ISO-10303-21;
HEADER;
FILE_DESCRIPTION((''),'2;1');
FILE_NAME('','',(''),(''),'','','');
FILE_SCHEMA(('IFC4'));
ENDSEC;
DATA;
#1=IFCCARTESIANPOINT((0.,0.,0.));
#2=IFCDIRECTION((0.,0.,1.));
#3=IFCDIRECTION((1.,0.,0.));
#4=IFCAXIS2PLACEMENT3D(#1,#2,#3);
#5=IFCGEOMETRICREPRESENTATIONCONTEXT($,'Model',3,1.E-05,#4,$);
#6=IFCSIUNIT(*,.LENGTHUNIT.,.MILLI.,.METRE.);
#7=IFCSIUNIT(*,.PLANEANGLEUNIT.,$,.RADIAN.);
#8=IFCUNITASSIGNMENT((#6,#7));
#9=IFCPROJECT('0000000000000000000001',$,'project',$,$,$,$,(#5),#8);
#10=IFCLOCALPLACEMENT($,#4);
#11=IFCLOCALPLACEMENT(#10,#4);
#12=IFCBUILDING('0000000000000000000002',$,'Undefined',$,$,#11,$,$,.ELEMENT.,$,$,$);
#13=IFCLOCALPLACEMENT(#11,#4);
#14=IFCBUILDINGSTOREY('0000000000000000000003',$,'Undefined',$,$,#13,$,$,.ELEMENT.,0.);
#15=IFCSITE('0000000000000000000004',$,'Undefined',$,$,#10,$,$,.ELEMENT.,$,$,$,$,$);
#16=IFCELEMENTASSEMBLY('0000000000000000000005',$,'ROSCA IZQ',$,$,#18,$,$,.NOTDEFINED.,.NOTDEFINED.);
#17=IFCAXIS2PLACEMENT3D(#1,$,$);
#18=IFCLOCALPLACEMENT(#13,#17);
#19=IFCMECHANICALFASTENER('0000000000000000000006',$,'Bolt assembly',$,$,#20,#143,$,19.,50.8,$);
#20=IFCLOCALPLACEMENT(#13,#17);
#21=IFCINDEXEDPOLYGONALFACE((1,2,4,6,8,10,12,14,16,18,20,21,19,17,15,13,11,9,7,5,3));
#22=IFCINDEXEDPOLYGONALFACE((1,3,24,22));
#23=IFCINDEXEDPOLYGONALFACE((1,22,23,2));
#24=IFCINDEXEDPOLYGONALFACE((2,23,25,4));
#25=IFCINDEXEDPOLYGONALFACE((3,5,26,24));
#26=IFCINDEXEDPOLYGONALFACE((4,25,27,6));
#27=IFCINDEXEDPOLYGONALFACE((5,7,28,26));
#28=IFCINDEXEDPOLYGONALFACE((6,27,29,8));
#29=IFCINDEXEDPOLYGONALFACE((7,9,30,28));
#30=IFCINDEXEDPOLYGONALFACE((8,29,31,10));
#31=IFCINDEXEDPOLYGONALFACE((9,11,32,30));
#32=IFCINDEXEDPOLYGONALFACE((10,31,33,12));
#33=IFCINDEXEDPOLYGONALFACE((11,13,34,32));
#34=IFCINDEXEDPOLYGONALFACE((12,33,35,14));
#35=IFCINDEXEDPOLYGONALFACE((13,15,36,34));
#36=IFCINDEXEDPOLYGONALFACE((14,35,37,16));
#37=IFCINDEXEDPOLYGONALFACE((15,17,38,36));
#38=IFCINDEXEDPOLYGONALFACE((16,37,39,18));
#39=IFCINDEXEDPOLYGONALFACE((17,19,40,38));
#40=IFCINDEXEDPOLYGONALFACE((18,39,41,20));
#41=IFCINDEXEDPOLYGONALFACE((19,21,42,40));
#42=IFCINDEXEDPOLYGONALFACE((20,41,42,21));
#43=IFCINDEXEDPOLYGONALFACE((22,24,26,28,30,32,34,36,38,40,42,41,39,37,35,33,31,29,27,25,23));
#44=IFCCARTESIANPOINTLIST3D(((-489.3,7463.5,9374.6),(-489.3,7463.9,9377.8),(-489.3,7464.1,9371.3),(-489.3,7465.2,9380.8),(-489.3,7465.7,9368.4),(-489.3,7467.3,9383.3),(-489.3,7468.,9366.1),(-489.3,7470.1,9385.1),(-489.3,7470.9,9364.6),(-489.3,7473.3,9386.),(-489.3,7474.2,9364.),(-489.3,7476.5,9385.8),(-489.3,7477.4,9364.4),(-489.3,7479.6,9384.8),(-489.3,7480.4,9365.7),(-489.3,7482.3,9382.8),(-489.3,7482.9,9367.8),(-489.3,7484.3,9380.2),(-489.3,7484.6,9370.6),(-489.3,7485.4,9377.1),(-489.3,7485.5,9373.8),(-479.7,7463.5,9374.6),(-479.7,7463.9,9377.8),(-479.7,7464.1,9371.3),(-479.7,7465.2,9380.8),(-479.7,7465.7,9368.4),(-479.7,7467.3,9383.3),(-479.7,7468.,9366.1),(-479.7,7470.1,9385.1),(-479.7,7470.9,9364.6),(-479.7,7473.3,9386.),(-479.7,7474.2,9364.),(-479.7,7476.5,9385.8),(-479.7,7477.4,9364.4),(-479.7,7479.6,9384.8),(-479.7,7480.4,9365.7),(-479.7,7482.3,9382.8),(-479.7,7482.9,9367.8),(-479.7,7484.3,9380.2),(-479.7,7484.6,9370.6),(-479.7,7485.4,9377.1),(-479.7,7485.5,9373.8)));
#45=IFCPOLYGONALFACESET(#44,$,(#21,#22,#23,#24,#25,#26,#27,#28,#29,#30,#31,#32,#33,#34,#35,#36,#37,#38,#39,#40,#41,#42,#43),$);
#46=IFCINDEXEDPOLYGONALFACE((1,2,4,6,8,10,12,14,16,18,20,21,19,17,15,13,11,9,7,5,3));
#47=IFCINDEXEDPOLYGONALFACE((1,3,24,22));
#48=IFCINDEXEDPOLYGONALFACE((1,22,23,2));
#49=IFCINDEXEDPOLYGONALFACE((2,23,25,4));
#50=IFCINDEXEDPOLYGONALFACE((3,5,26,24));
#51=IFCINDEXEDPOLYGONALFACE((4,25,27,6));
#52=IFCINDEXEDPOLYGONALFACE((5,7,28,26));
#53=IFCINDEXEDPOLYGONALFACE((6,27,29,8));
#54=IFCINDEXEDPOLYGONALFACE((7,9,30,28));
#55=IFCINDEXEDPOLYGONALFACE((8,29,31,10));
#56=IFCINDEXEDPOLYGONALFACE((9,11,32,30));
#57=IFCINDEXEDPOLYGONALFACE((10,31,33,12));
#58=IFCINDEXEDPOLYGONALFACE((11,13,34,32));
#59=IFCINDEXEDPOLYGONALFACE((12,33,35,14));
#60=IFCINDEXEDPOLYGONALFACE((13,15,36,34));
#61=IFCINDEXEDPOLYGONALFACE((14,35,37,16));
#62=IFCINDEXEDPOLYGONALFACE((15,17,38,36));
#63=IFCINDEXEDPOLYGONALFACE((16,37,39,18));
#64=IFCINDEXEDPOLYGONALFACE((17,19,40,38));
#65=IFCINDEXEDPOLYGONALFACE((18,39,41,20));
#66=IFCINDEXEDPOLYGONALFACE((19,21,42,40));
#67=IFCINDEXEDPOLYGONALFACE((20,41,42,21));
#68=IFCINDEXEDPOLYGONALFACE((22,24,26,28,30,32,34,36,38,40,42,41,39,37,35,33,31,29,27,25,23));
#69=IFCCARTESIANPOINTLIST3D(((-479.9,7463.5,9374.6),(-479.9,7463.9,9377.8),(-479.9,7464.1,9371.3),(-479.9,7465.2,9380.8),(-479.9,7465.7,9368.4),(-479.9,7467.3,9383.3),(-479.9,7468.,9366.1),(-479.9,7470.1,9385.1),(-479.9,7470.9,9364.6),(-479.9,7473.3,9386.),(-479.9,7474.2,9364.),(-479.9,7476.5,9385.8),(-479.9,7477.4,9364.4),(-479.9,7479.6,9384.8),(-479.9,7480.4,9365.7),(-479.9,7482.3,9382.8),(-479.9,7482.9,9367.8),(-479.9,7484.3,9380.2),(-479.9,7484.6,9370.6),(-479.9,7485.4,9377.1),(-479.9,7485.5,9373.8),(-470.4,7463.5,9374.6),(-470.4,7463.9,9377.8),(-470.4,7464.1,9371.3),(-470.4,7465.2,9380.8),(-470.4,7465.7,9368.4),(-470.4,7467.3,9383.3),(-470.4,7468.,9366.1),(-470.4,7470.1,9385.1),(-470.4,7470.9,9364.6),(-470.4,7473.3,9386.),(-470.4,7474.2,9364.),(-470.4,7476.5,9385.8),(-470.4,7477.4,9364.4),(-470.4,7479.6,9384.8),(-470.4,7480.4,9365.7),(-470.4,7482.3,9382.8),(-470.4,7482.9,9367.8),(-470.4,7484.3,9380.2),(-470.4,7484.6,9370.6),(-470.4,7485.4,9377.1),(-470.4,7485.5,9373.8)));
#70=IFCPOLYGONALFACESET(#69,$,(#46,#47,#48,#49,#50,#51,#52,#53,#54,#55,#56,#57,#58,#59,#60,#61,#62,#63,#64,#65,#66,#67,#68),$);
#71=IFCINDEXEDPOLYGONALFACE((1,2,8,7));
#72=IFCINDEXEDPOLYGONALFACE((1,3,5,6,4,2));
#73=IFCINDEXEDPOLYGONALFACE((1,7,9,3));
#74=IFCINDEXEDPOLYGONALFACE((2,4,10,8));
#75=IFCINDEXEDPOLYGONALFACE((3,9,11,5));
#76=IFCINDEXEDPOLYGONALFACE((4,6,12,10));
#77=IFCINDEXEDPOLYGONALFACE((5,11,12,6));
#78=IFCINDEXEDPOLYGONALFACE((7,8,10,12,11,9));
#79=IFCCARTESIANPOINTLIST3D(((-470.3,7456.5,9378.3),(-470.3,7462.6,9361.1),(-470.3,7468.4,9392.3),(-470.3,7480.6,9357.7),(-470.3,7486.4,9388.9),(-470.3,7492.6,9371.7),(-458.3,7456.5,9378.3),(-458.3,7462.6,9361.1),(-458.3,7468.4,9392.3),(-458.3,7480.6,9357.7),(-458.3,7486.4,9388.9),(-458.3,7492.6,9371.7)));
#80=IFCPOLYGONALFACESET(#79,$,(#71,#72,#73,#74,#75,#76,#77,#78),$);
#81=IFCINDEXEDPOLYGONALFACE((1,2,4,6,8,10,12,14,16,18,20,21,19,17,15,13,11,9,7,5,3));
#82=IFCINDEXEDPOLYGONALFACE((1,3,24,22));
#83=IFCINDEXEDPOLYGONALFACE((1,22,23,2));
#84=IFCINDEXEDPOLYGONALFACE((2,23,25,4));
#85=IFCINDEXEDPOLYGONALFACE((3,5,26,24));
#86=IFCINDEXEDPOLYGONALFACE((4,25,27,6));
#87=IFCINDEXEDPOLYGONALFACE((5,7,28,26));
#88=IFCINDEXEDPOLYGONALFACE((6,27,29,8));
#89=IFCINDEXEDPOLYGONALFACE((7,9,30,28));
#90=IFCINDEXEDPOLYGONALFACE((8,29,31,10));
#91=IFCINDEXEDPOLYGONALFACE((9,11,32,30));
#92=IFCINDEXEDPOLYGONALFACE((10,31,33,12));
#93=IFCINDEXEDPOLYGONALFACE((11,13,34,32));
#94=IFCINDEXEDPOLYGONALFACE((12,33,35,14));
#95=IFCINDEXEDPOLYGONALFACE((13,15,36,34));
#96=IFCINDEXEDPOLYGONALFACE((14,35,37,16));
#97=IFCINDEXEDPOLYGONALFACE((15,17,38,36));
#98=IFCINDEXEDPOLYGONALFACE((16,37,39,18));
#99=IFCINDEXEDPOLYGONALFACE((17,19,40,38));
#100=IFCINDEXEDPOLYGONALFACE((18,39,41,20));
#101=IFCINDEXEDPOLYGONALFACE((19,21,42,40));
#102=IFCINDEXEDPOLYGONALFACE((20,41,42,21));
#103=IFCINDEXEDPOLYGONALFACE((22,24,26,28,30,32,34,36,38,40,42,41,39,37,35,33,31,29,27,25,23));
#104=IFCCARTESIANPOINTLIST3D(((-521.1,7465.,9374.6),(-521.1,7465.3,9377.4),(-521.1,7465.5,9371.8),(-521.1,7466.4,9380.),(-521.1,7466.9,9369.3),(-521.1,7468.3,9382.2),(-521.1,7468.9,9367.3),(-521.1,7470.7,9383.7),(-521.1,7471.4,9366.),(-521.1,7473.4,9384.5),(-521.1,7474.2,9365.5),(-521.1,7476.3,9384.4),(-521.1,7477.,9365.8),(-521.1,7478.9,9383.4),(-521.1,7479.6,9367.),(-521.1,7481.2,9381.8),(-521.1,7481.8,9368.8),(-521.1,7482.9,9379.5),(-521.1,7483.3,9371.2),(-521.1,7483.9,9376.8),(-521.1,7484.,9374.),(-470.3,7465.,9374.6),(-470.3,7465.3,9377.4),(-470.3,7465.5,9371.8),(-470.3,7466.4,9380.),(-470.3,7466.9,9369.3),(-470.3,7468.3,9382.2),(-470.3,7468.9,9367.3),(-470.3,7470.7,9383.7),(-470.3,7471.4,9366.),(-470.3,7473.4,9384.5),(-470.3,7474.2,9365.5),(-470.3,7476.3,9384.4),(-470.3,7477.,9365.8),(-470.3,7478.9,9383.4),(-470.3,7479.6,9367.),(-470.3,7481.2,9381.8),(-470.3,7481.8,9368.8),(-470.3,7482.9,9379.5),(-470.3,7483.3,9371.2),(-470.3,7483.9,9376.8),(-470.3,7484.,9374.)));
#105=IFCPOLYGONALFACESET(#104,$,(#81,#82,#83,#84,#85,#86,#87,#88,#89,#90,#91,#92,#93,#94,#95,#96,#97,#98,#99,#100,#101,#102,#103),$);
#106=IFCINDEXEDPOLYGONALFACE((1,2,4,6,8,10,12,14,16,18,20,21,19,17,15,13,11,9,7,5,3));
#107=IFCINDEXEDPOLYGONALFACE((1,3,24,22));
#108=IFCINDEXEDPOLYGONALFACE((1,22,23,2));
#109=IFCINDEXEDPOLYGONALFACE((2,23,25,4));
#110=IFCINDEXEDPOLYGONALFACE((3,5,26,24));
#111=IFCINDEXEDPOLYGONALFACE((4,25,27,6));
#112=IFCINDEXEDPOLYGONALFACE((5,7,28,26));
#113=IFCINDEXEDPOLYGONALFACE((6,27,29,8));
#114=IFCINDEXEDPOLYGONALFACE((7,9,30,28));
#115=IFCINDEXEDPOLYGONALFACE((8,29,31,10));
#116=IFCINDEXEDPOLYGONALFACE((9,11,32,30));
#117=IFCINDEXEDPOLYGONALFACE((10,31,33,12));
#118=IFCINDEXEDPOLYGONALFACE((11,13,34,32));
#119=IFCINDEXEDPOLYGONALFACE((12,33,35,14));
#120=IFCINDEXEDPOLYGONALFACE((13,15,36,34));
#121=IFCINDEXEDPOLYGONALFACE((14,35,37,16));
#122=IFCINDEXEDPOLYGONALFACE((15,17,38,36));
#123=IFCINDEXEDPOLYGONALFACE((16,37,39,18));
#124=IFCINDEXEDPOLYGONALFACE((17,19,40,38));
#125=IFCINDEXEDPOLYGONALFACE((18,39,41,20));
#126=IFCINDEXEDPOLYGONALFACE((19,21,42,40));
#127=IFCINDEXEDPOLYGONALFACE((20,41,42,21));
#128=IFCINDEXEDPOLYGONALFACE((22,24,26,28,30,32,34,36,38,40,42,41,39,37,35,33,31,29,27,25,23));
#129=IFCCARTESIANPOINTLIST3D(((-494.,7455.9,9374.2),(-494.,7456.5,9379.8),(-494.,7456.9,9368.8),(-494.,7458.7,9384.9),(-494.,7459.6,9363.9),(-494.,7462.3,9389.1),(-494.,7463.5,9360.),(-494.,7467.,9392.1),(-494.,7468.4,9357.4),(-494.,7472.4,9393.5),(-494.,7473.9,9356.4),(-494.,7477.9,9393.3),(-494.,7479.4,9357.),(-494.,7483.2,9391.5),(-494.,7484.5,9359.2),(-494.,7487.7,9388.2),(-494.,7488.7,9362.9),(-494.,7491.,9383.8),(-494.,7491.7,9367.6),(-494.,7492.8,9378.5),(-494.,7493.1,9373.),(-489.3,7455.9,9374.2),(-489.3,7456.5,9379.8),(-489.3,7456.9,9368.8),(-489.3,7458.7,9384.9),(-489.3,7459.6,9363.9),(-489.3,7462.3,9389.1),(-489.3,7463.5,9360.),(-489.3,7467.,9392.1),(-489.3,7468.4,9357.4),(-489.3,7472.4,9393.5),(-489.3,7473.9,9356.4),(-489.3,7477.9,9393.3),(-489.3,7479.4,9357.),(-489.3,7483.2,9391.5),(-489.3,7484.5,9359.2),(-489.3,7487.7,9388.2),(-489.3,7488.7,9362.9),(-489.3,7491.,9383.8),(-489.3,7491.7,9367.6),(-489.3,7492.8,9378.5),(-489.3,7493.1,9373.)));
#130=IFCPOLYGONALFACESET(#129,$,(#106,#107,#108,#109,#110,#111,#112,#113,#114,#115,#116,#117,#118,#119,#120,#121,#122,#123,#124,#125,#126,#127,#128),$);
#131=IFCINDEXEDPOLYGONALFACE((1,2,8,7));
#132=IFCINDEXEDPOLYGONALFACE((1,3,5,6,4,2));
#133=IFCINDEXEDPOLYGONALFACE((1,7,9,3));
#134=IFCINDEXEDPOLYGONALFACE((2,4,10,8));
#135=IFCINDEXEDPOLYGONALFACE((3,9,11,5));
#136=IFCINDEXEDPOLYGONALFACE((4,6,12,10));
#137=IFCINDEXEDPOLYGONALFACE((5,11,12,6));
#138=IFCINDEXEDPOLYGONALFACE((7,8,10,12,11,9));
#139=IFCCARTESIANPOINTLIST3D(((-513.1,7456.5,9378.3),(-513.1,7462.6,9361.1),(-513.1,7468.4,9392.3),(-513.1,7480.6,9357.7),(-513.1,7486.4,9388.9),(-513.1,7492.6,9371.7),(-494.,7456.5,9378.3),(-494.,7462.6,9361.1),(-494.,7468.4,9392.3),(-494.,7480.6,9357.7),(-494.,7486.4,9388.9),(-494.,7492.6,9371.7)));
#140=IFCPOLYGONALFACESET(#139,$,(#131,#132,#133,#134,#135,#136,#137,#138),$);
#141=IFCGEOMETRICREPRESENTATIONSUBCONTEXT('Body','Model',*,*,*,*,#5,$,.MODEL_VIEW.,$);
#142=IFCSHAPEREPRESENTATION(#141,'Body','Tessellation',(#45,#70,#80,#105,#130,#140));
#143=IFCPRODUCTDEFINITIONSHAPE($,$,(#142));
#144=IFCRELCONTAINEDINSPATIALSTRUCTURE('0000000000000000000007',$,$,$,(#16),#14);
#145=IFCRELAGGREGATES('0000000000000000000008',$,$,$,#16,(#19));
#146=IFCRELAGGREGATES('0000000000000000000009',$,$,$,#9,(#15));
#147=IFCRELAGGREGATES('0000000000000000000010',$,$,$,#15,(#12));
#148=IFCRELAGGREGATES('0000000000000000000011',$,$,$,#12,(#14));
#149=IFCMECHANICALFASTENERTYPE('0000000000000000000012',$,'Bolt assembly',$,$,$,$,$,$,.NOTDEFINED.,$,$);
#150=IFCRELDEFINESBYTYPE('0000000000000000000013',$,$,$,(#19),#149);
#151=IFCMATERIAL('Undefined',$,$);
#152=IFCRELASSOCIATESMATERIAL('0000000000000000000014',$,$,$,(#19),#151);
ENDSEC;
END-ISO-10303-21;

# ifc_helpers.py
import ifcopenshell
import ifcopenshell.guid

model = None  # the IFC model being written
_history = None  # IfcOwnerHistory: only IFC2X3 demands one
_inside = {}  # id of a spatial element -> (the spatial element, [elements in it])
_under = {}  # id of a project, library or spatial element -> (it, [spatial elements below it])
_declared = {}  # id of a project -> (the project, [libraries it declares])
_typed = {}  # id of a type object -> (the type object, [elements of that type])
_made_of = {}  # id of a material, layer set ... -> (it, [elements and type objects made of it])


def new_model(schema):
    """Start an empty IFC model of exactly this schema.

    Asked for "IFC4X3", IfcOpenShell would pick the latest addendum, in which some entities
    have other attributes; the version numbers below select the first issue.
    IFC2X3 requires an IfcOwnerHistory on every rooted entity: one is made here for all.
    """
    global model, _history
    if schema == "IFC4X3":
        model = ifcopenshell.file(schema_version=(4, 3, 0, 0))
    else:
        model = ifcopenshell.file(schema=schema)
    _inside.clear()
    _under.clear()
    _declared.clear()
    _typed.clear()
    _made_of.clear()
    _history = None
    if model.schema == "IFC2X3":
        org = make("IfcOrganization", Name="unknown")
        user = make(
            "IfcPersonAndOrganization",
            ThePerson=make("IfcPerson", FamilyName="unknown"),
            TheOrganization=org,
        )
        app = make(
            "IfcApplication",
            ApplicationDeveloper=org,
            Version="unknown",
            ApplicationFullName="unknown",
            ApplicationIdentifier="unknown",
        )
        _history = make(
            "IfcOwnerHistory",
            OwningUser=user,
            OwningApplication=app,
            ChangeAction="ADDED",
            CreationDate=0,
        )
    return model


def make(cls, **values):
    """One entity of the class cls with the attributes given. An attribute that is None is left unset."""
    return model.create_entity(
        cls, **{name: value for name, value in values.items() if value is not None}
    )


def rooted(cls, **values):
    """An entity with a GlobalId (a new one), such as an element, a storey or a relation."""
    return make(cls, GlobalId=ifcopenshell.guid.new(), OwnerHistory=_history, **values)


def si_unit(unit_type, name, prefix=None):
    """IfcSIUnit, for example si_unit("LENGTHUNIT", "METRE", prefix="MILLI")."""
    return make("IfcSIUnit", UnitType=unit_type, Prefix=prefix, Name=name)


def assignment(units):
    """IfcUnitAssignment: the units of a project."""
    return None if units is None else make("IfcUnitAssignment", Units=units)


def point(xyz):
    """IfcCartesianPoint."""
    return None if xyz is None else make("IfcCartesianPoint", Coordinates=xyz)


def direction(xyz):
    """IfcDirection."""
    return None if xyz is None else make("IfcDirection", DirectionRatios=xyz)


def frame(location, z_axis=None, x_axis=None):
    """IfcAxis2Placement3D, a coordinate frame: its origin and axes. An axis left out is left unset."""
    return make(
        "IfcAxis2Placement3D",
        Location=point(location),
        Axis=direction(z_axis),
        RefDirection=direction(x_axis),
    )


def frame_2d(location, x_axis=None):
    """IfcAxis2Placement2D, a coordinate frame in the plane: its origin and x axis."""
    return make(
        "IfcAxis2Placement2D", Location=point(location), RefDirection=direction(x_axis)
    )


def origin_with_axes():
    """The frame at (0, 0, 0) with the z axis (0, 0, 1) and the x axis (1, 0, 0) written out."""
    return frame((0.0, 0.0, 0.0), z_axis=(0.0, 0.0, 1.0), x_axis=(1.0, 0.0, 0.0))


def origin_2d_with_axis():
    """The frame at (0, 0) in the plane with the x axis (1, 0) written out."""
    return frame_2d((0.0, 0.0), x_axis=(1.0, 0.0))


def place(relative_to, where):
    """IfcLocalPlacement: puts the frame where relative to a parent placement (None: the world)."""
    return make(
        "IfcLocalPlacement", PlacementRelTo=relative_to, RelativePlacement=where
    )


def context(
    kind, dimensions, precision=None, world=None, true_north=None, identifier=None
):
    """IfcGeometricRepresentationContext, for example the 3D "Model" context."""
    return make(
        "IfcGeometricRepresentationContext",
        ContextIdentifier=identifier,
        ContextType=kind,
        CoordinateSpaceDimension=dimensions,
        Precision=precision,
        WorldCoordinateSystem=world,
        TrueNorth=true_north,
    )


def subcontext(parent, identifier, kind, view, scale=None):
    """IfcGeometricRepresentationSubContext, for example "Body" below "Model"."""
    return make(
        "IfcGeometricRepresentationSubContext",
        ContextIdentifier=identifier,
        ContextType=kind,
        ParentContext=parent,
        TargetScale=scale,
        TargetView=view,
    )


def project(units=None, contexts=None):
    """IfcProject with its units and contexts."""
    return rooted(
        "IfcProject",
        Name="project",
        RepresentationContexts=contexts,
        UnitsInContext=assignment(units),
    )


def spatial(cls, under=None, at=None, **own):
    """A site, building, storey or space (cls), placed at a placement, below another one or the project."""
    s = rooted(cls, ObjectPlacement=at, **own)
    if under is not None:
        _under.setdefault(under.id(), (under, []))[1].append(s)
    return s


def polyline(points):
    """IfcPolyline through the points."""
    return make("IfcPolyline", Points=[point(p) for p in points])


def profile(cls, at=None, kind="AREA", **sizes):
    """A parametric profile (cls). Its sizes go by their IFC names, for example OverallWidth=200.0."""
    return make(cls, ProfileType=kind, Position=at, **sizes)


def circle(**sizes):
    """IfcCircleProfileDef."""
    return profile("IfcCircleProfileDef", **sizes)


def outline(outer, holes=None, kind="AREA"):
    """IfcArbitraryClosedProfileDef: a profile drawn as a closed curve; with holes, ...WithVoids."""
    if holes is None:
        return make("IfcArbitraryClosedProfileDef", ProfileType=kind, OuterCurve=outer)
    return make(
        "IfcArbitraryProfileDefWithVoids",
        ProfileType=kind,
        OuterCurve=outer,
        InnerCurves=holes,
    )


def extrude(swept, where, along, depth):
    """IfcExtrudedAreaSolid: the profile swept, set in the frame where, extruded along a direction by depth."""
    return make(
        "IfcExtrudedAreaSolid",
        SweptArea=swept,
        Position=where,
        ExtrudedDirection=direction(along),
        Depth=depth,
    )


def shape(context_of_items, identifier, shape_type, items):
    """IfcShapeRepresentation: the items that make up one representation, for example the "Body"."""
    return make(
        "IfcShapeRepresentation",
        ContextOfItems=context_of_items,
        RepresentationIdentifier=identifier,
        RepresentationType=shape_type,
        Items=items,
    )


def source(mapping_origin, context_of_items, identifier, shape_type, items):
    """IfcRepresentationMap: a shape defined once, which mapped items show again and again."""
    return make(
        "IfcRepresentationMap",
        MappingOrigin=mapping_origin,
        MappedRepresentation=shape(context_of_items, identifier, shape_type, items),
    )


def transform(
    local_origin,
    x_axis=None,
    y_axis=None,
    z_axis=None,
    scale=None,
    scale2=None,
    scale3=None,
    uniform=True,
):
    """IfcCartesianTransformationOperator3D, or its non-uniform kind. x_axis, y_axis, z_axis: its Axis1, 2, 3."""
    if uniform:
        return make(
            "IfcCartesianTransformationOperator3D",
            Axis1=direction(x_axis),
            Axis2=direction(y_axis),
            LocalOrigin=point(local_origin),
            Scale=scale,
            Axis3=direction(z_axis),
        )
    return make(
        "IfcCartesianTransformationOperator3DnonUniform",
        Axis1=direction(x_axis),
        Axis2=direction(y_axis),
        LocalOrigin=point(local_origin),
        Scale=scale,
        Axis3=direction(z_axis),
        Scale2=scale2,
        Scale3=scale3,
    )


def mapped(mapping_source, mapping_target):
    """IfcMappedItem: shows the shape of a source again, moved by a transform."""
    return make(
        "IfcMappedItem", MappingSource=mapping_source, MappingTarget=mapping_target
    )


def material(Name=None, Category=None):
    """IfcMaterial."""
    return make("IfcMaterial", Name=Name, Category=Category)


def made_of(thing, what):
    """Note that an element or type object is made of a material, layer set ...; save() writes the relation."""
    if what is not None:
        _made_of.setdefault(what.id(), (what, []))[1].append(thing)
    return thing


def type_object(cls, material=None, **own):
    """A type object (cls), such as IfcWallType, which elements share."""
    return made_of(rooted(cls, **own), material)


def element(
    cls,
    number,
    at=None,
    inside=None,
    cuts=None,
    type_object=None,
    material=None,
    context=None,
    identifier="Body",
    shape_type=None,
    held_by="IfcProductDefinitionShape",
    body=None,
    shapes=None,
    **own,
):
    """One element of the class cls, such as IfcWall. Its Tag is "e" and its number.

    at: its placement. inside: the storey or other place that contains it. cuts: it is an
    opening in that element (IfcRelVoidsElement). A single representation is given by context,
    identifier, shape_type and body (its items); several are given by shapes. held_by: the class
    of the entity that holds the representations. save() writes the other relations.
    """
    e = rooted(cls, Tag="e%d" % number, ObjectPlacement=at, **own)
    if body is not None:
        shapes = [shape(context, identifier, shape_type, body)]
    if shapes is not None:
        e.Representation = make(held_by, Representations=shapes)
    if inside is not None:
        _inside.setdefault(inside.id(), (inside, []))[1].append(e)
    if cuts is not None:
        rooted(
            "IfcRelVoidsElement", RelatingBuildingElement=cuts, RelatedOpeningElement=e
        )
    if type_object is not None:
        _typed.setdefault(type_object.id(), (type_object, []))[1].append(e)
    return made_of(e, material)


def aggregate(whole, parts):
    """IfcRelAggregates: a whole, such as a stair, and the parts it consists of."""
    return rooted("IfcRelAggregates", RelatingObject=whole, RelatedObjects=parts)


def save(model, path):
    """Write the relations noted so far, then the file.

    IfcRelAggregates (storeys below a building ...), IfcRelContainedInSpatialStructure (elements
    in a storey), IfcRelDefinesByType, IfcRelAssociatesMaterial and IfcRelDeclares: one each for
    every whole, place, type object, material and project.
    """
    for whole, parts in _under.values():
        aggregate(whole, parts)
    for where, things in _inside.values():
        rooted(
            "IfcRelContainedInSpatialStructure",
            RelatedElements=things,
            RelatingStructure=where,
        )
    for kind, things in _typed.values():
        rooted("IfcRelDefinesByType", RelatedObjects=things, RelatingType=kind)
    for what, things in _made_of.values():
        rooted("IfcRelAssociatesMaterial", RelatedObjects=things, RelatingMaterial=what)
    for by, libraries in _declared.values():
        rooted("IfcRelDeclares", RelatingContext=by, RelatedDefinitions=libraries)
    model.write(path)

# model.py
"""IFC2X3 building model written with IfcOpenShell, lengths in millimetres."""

from ifc_helpers import new_model, si_unit, frame, origin_with_axes, origin_2d_with_axis, place, context, subcontext, project, spatial, polyline, circle, outline, extrude, source, transform, mapped, material, type_object, element, aggregate, save


model = new_model("IFC2X3")

# Units and contexts
model_context = context("Model", 3, precision=1e-05, world=origin_with_axes())
body_context = subcontext(model_context, "Body", "Model", "MODEL_VIEW")
ifc_project = project(units=[si_unit("LENGTHUNIT", "METRE", prefix="MILLI"), si_unit("PLANEANGLEUNIT", "RADIAN")], contexts=[model_context])

# Site, building, storey
site_placement = place(None, origin_with_axes())
site = spatial("IfcSite", under=ifc_project, at=site_placement, Name="Undefined", CompositionType="ELEMENT")
building_placement = place(site_placement, origin_with_axes())
building = spatial("IfcBuilding", under=site, at=building_placement, Name="Undefined", CompositionType="ELEMENT")
storey_placement = place(building_placement, origin_with_axes())
storey = spatial("IfcBuildingStorey", under=building, at=storey_placement, Name="Undefined", CompositionType="ELEMENT", Elevation=0.0)

# Element assembly, mechanical fastener
assembly_1_placement = place(storey_placement, origin_with_axes())
assembly_1 = element("IfcElementAssembly", 1, at=assembly_1_placement, inside=storey, Name="ROSCA IZQ", AssemblyPlace="NOTDEFINED", PredefinedType="NOTDEFINED")
ifc_material_1 = material(Name="Undefined")
mechanical_fastener_type = type_object("IfcMechanicalFastenerType", Name="Bolt assembly")
shared_shape_1 = source(origin_with_axes(), body_context, "Body", "SweptSolid", [
    extrude(circle(Radius=11.0, at=origin_2d_with_axis()), frame((0.0, 4.6, 0.0), z_axis=(0.0, 1.0, 0.0), x_axis=(1.0, 0.0, 0.0)), (0.0, 0.0, 1.0), 9.6),
    extrude(circle(Radius=11.0, at=origin_2d_with_axis()), frame((0.0, -4.6, 0.0), z_axis=(0.0, 1.0, 0.0), x_axis=(1.0, 0.0, 0.0)), (0.0, 0.0, 1.0), 9.5),
    extrude(outline(polyline([(15.9, -9.2), (15.9, 9.2), (0.0, 18.3), (-15.9, 9.2), (-15.9, -9.2), (0.0, -18.3), (15.9, -9.2)])), frame((0.0, -16.7, 0.0), z_axis=(0.0, 1.0, 0.0), x_axis=(1.0, 0.0, 0.0)), (0.0, 0.0, 1.0), 11.9),
    extrude(circle(Radius=9.5, at=origin_2d_with_axis()), frame((0.0, -4.7, 0.0), z_axis=(0.0, 1.0, 0.0), x_axis=(1.0, 0.0, 0.0)), (0.0, 0.0, 1.0), 50.8),
    extrude(circle(Radius=18.7, at=origin_2d_with_axis()), frame((0.0, 14.2, 0.0), z_axis=(0.0, 1.0, 0.0), x_axis=(1.0, 0.0, 0.0)), (0.0, 0.0, 1.0), 4.8),
    extrude(outline(polyline([(15.9, -9.2), (15.9, 9.2), (0.0, 18.3), (-15.9, 9.2), (-15.9, -9.2), (0.0, -18.3), (15.9, -9.2)])), frame((0.0, 19.0, 0.0), z_axis=(0.0, 1.0, 0.0), x_axis=(1.0, 0.0, 0.0)), (0.0, 0.0, 1.0), 19.1),
])
mechanical_fastener_1_placement = place(assembly_1_placement, frame((-475.0, 7474.5, 9375.0), z_axis=(0.0, 0.333508, -0.942747), x_axis=(0.0, -0.942747, -0.333508)))
mechanical_fastener_1 = element("IfcMechanicalFastener", 2, at=mechanical_fastener_1_placement, type_object=mechanical_fastener_type, material=ifc_material_1, Name="Bolt assembly", NominalDiameter=19.0, NominalLength=50.8, context=body_context, shape_type="MappedRepresentation", body=[
    mapped(shared_shape_1, transform((0.0, 0.0, 0.0))),
])
aggregate(assembly_1, [mechanical_fastener_1])

save(model, "model.ifc")
